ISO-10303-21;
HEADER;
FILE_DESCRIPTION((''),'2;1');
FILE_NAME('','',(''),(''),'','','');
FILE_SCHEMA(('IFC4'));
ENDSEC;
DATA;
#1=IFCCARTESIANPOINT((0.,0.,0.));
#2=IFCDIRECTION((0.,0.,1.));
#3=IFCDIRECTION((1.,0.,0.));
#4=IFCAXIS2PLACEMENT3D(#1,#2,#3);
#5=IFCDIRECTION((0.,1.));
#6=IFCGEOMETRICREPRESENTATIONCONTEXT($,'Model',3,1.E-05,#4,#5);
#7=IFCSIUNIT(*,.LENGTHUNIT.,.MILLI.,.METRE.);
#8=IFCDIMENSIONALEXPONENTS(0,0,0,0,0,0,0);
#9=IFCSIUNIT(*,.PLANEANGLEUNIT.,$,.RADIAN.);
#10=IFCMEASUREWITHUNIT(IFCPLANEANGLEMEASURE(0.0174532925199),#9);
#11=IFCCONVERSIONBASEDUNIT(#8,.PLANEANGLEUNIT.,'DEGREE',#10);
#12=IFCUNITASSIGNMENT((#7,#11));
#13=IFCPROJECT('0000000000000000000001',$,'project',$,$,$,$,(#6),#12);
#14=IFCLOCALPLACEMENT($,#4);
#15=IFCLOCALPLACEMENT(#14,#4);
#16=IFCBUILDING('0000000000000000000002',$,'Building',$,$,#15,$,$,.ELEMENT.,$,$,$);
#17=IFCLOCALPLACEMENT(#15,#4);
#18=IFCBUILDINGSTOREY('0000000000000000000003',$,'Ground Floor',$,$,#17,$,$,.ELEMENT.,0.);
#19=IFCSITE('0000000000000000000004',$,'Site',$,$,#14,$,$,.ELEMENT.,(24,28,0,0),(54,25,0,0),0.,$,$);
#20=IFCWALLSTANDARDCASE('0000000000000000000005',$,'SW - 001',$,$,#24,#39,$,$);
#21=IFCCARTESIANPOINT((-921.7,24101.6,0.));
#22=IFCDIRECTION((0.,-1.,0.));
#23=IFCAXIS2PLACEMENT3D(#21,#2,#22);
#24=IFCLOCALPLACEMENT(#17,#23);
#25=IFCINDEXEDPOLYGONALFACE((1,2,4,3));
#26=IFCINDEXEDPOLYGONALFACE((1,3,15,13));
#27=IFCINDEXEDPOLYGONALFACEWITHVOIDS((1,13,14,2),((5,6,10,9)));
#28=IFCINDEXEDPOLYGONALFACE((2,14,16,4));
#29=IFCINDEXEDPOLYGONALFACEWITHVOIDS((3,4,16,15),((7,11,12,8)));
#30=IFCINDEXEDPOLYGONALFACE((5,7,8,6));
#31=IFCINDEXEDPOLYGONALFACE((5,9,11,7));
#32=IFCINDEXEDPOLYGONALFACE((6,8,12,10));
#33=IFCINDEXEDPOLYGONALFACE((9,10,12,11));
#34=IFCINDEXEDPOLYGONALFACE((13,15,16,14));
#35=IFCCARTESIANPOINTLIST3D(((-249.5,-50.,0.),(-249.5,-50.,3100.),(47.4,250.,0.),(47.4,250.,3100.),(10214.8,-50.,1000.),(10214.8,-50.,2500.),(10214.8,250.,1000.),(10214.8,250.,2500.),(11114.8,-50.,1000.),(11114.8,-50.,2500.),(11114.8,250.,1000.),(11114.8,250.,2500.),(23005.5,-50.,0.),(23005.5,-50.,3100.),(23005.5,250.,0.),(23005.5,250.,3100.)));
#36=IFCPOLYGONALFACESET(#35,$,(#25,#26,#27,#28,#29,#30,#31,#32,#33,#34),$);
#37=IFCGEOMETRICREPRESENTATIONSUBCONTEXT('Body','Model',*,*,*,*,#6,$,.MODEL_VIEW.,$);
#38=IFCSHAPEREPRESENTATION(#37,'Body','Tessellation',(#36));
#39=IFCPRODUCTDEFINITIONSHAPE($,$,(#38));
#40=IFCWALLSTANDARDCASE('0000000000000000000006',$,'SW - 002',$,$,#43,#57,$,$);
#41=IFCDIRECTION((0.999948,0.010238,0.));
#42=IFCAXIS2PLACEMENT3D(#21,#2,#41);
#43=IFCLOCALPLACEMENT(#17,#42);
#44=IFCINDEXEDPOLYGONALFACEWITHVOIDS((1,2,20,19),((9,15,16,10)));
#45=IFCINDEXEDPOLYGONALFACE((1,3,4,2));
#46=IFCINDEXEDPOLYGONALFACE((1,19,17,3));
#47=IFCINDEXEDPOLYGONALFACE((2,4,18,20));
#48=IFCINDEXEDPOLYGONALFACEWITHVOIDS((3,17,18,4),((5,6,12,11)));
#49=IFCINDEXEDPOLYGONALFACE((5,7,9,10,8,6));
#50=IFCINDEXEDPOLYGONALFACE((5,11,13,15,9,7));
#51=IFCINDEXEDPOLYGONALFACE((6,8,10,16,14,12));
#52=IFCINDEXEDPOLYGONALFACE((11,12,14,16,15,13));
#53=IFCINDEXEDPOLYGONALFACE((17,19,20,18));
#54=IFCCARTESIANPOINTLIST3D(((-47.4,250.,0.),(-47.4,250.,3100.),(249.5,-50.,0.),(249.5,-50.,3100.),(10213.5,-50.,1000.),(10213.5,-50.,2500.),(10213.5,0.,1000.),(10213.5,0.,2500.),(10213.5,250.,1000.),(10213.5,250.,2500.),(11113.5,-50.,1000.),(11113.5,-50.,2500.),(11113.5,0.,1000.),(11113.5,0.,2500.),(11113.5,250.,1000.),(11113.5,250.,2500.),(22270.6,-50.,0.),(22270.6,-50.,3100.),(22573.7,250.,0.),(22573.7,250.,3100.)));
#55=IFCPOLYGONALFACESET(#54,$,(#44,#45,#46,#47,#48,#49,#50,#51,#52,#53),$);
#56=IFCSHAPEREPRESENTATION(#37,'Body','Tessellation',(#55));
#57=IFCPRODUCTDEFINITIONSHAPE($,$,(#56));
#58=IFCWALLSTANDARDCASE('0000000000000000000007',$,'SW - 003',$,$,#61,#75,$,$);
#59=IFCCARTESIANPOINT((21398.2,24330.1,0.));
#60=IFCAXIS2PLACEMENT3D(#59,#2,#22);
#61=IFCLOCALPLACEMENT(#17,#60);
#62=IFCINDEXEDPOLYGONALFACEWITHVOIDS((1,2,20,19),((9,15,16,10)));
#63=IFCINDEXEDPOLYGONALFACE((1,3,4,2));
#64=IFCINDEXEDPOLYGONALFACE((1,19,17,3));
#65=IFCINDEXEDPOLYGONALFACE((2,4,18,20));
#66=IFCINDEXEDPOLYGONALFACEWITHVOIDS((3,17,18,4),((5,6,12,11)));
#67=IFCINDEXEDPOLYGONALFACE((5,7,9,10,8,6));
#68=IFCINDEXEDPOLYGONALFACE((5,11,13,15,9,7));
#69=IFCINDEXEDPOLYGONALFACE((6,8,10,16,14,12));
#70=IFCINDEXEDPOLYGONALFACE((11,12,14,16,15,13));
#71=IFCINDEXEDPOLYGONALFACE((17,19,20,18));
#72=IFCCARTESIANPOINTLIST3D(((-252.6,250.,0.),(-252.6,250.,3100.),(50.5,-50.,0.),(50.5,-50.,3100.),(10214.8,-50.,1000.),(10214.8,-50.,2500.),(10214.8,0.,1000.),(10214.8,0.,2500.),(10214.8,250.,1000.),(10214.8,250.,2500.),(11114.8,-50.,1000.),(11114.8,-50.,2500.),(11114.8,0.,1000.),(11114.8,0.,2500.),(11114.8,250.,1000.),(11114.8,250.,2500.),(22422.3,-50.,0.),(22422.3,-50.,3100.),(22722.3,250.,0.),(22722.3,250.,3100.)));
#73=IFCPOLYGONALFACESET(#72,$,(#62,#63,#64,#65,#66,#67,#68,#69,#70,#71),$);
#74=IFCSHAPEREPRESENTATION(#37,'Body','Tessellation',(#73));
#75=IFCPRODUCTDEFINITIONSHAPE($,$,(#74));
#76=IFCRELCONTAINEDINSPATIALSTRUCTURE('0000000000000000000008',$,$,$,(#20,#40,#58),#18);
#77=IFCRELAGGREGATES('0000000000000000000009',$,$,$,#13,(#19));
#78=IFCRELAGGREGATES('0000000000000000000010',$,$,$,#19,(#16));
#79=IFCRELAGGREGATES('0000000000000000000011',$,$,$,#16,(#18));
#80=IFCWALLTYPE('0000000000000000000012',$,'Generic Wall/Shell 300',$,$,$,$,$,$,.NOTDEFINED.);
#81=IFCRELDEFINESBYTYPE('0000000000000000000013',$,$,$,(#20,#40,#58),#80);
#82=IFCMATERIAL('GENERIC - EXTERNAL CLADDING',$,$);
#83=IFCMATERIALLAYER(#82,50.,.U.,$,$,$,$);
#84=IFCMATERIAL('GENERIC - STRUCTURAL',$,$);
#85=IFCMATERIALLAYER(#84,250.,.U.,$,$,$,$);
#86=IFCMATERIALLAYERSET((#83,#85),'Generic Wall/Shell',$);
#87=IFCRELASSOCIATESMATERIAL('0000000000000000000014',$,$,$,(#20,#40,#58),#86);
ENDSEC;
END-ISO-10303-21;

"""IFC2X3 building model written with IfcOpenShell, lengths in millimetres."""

from ifc_helpers import new_model, entity, si_unit, converted_unit, direction, frame, origin_with_axes, origin_2d_with_axis, place, context, subcontext, project, spatial, polyline, rectangle, outline, extrude, material, layer, layer_set, layer_usage, type_object, element, save


model = new_model("IFC2X3")

# Units and contexts
model_context = context("Model", 3, precision=1e-05, world=origin_with_axes(), true_north=direction((0.0, 1.0)))
body_context = subcontext(model_context, "Body", "Model", "MODEL_VIEW")
ifc_project = project(units=[si_unit("LENGTHUNIT", "METRE", prefix="MILLI"), converted_unit("PLANEANGLEUNIT", "DEGREE", entity("IfcPlaneAngleMeasure", 0.0174532925199), si_unit("PLANEANGLEUNIT", "RADIAN"), dimensions=[0, 0, 0, 0, 0, 0, 0])], contexts=[model_context])

# Site, building, storey
site_placement = place(None, origin_with_axes())
site = spatial("IfcSite", under=ifc_project, at=site_placement, Name="Site", CompositionType="ELEMENT", RefLatitude=(24, 28, 0, 0), RefLongitude=(54, 25, 0, 0), RefElevation=0.0)
building_placement = place(site_placement, origin_with_axes())
building = spatial("IfcBuilding", under=site, at=building_placement, Name="Building", CompositionType="ELEMENT")
storey_placement = place(building_placement, origin_with_axes())
storey = spatial("IfcBuildingStorey", under=building, at=storey_placement, Name="Ground Floor", CompositionType="ELEMENT", Elevation=0.0)

# Walls, openings
ifc_material_1 = material(Name="GENERIC - EXTERNAL CLADDING")
ifc_layer_1 = layer(ifc_material_1, 50.0, ventilated="UNKNOWN")
ifc_material_2 = material(Name="GENERIC - STRUCTURAL")
ifc_layer_2 = layer(ifc_material_2, 250.0, ventilated="UNKNOWN")
ifc_layer_set = layer_set([ifc_layer_1, ifc_layer_2], Name="Generic Wall/Shell")
ifc_layer_usage_1 = layer_usage(ifc_layer_set, "AXIS2", "POSITIVE", -50.0)
wall_type = type_object("IfcWallType", Name="Generic Wall/Shell 300", PredefinedType="NOTDEFINED")
wall_1_placement = place(storey_placement, frame((-921.7, 24101.6, 0.0), z_axis=(0.0, 0.0, 1.0), x_axis=(0.0, -1.0, 0.0)))
wall_1 = element("IfcWallStandardCase", 1, at=wall_1_placement, inside=storey, type_object=wall_type, material=ifc_layer_usage_1, Name="SW - 001", context=body_context, shape_type="SweptSolid", body=[
    extrude(outline(polyline([(-249.5, -50.0), (23005.5, -50.0), (23005.5, 250.0), (47.4, 250.0), (-249.5, -50.0)])), origin_with_axes(), (0.0, 0.0, 1.0), 3100.0),
])
opening_1_placement = place(wall_1_placement, frame((10664.8, 0.0, 1000.0), z_axis=(0.0, 0.0, 1.0), x_axis=(1.0, 0.0, 0.0)))
element("IfcOpeningElement", 2, at=opening_1_placement, cuts=wall_1, context=body_context, shape_type="SweptSolid", body=[
    extrude(rectangle(XDim=900.0, YDim=1500.0, at=origin_2d_with_axis()), frame((0.0, -350.0, 750.0), z_axis=(0.0, 1.0, 0.0), x_axis=(-1.0, 0.0, 0.0)), (0.0, 0.0, 1.0), 900.0),
])
ifc_layer_usage_2 = layer_usage(ifc_layer_set, "AXIS2", "POSITIVE", -50.0)
wall_2_placement = place(storey_placement, frame((-921.7, 24101.6, 0.0), z_axis=(0.0, 0.0, 1.0), x_axis=(0.999948, 0.010238, 0.0)))
wall_2 = element("IfcWallStandardCase", 3, at=wall_2_placement, inside=storey, type_object=wall_type, material=ifc_layer_usage_2, Name="SW - 002", context=body_context, shape_type="SweptSolid", body=[
    extrude(outline(polyline([(249.5, -50.0), (22270.6, -50.0), (22573.7, 250.0), (-47.4, 250.0), (249.5, -50.0)])), origin_with_axes(), (0.0, 0.0, 1.0), 3100.0),
])
opening_2_placement = place(wall_2_placement, frame((10663.5, 0.0, 1000.0), z_axis=(0.0, 0.0, 1.0), x_axis=(1.0, 0.0, 0.0)))
element("IfcOpeningElement", 4, at=opening_2_placement, cuts=wall_2, context=body_context, shape_type="SweptSolid", body=[
    extrude(rectangle(XDim=900.0, YDim=1500.0, at=origin_2d_with_axis()), frame((0.0, 550.0, 750.0), z_axis=(0.0, -1.0, 0.0), x_axis=(1.0, 0.0, 0.0)), (0.0, 0.0, 1.0), 550.0),
    extrude(rectangle(XDim=900.0, YDim=1500.0, at=origin_2d_with_axis()), frame((0.0, -350.0, 750.0), z_axis=(0.0, 1.0, 0.0), x_axis=(1.0, 0.0, 0.0)), (0.0, 0.0, 1.0), 350.0),
])
ifc_layer_usage_3 = layer_usage(ifc_layer_set, "AXIS2", "POSITIVE", -50.0)
wall_3_placement = place(storey_placement, frame((21398.2, 24330.1, 0.0), z_axis=(0.0, 0.0, 1.0), x_axis=(0.0, -1.0, 0.0)))
wall_3 = element("IfcWallStandardCase", 5, at=wall_3_placement, inside=storey, type_object=wall_type, material=ifc_layer_usage_3, Name="SW - 003", context=body_context, shape_type="SweptSolid", body=[
    extrude(outline(polyline([(50.5, -50.0), (22422.3, -50.0), (22722.3, 250.0), (-252.6, 250.0), (50.5, -50.0)])), origin_with_axes(), (0.0, 0.0, 1.0), 3100.0),
])
opening_3_placement = place(wall_3_placement, frame((10664.8, 0.0, 1000.0), z_axis=(0.0, 0.0, 1.0), x_axis=(1.0, 0.0, 0.0)))
element("IfcOpeningElement", 6, at=opening_3_placement, cuts=wall_3, context=body_context, shape_type="SweptSolid", body=[
    extrude(rectangle(XDim=900.0, YDim=1500.0, at=origin_2d_with_axis()), frame((0.0, 550.0, 750.0), z_axis=(0.0, -1.0, 0.0), x_axis=(1.0, 0.0, 0.0)), (0.0, 0.0, 1.0), 550.0),
    extrude(rectangle(XDim=900.0, YDim=1500.0, at=origin_2d_with_axis()), frame((0.0, -350.0, 750.0), z_axis=(0.0, 1.0, 0.0), x_axis=(1.0, 0.0, 0.0)), (0.0, 0.0, 1.0), 350.0),
])

save(model, "model.ifc")
